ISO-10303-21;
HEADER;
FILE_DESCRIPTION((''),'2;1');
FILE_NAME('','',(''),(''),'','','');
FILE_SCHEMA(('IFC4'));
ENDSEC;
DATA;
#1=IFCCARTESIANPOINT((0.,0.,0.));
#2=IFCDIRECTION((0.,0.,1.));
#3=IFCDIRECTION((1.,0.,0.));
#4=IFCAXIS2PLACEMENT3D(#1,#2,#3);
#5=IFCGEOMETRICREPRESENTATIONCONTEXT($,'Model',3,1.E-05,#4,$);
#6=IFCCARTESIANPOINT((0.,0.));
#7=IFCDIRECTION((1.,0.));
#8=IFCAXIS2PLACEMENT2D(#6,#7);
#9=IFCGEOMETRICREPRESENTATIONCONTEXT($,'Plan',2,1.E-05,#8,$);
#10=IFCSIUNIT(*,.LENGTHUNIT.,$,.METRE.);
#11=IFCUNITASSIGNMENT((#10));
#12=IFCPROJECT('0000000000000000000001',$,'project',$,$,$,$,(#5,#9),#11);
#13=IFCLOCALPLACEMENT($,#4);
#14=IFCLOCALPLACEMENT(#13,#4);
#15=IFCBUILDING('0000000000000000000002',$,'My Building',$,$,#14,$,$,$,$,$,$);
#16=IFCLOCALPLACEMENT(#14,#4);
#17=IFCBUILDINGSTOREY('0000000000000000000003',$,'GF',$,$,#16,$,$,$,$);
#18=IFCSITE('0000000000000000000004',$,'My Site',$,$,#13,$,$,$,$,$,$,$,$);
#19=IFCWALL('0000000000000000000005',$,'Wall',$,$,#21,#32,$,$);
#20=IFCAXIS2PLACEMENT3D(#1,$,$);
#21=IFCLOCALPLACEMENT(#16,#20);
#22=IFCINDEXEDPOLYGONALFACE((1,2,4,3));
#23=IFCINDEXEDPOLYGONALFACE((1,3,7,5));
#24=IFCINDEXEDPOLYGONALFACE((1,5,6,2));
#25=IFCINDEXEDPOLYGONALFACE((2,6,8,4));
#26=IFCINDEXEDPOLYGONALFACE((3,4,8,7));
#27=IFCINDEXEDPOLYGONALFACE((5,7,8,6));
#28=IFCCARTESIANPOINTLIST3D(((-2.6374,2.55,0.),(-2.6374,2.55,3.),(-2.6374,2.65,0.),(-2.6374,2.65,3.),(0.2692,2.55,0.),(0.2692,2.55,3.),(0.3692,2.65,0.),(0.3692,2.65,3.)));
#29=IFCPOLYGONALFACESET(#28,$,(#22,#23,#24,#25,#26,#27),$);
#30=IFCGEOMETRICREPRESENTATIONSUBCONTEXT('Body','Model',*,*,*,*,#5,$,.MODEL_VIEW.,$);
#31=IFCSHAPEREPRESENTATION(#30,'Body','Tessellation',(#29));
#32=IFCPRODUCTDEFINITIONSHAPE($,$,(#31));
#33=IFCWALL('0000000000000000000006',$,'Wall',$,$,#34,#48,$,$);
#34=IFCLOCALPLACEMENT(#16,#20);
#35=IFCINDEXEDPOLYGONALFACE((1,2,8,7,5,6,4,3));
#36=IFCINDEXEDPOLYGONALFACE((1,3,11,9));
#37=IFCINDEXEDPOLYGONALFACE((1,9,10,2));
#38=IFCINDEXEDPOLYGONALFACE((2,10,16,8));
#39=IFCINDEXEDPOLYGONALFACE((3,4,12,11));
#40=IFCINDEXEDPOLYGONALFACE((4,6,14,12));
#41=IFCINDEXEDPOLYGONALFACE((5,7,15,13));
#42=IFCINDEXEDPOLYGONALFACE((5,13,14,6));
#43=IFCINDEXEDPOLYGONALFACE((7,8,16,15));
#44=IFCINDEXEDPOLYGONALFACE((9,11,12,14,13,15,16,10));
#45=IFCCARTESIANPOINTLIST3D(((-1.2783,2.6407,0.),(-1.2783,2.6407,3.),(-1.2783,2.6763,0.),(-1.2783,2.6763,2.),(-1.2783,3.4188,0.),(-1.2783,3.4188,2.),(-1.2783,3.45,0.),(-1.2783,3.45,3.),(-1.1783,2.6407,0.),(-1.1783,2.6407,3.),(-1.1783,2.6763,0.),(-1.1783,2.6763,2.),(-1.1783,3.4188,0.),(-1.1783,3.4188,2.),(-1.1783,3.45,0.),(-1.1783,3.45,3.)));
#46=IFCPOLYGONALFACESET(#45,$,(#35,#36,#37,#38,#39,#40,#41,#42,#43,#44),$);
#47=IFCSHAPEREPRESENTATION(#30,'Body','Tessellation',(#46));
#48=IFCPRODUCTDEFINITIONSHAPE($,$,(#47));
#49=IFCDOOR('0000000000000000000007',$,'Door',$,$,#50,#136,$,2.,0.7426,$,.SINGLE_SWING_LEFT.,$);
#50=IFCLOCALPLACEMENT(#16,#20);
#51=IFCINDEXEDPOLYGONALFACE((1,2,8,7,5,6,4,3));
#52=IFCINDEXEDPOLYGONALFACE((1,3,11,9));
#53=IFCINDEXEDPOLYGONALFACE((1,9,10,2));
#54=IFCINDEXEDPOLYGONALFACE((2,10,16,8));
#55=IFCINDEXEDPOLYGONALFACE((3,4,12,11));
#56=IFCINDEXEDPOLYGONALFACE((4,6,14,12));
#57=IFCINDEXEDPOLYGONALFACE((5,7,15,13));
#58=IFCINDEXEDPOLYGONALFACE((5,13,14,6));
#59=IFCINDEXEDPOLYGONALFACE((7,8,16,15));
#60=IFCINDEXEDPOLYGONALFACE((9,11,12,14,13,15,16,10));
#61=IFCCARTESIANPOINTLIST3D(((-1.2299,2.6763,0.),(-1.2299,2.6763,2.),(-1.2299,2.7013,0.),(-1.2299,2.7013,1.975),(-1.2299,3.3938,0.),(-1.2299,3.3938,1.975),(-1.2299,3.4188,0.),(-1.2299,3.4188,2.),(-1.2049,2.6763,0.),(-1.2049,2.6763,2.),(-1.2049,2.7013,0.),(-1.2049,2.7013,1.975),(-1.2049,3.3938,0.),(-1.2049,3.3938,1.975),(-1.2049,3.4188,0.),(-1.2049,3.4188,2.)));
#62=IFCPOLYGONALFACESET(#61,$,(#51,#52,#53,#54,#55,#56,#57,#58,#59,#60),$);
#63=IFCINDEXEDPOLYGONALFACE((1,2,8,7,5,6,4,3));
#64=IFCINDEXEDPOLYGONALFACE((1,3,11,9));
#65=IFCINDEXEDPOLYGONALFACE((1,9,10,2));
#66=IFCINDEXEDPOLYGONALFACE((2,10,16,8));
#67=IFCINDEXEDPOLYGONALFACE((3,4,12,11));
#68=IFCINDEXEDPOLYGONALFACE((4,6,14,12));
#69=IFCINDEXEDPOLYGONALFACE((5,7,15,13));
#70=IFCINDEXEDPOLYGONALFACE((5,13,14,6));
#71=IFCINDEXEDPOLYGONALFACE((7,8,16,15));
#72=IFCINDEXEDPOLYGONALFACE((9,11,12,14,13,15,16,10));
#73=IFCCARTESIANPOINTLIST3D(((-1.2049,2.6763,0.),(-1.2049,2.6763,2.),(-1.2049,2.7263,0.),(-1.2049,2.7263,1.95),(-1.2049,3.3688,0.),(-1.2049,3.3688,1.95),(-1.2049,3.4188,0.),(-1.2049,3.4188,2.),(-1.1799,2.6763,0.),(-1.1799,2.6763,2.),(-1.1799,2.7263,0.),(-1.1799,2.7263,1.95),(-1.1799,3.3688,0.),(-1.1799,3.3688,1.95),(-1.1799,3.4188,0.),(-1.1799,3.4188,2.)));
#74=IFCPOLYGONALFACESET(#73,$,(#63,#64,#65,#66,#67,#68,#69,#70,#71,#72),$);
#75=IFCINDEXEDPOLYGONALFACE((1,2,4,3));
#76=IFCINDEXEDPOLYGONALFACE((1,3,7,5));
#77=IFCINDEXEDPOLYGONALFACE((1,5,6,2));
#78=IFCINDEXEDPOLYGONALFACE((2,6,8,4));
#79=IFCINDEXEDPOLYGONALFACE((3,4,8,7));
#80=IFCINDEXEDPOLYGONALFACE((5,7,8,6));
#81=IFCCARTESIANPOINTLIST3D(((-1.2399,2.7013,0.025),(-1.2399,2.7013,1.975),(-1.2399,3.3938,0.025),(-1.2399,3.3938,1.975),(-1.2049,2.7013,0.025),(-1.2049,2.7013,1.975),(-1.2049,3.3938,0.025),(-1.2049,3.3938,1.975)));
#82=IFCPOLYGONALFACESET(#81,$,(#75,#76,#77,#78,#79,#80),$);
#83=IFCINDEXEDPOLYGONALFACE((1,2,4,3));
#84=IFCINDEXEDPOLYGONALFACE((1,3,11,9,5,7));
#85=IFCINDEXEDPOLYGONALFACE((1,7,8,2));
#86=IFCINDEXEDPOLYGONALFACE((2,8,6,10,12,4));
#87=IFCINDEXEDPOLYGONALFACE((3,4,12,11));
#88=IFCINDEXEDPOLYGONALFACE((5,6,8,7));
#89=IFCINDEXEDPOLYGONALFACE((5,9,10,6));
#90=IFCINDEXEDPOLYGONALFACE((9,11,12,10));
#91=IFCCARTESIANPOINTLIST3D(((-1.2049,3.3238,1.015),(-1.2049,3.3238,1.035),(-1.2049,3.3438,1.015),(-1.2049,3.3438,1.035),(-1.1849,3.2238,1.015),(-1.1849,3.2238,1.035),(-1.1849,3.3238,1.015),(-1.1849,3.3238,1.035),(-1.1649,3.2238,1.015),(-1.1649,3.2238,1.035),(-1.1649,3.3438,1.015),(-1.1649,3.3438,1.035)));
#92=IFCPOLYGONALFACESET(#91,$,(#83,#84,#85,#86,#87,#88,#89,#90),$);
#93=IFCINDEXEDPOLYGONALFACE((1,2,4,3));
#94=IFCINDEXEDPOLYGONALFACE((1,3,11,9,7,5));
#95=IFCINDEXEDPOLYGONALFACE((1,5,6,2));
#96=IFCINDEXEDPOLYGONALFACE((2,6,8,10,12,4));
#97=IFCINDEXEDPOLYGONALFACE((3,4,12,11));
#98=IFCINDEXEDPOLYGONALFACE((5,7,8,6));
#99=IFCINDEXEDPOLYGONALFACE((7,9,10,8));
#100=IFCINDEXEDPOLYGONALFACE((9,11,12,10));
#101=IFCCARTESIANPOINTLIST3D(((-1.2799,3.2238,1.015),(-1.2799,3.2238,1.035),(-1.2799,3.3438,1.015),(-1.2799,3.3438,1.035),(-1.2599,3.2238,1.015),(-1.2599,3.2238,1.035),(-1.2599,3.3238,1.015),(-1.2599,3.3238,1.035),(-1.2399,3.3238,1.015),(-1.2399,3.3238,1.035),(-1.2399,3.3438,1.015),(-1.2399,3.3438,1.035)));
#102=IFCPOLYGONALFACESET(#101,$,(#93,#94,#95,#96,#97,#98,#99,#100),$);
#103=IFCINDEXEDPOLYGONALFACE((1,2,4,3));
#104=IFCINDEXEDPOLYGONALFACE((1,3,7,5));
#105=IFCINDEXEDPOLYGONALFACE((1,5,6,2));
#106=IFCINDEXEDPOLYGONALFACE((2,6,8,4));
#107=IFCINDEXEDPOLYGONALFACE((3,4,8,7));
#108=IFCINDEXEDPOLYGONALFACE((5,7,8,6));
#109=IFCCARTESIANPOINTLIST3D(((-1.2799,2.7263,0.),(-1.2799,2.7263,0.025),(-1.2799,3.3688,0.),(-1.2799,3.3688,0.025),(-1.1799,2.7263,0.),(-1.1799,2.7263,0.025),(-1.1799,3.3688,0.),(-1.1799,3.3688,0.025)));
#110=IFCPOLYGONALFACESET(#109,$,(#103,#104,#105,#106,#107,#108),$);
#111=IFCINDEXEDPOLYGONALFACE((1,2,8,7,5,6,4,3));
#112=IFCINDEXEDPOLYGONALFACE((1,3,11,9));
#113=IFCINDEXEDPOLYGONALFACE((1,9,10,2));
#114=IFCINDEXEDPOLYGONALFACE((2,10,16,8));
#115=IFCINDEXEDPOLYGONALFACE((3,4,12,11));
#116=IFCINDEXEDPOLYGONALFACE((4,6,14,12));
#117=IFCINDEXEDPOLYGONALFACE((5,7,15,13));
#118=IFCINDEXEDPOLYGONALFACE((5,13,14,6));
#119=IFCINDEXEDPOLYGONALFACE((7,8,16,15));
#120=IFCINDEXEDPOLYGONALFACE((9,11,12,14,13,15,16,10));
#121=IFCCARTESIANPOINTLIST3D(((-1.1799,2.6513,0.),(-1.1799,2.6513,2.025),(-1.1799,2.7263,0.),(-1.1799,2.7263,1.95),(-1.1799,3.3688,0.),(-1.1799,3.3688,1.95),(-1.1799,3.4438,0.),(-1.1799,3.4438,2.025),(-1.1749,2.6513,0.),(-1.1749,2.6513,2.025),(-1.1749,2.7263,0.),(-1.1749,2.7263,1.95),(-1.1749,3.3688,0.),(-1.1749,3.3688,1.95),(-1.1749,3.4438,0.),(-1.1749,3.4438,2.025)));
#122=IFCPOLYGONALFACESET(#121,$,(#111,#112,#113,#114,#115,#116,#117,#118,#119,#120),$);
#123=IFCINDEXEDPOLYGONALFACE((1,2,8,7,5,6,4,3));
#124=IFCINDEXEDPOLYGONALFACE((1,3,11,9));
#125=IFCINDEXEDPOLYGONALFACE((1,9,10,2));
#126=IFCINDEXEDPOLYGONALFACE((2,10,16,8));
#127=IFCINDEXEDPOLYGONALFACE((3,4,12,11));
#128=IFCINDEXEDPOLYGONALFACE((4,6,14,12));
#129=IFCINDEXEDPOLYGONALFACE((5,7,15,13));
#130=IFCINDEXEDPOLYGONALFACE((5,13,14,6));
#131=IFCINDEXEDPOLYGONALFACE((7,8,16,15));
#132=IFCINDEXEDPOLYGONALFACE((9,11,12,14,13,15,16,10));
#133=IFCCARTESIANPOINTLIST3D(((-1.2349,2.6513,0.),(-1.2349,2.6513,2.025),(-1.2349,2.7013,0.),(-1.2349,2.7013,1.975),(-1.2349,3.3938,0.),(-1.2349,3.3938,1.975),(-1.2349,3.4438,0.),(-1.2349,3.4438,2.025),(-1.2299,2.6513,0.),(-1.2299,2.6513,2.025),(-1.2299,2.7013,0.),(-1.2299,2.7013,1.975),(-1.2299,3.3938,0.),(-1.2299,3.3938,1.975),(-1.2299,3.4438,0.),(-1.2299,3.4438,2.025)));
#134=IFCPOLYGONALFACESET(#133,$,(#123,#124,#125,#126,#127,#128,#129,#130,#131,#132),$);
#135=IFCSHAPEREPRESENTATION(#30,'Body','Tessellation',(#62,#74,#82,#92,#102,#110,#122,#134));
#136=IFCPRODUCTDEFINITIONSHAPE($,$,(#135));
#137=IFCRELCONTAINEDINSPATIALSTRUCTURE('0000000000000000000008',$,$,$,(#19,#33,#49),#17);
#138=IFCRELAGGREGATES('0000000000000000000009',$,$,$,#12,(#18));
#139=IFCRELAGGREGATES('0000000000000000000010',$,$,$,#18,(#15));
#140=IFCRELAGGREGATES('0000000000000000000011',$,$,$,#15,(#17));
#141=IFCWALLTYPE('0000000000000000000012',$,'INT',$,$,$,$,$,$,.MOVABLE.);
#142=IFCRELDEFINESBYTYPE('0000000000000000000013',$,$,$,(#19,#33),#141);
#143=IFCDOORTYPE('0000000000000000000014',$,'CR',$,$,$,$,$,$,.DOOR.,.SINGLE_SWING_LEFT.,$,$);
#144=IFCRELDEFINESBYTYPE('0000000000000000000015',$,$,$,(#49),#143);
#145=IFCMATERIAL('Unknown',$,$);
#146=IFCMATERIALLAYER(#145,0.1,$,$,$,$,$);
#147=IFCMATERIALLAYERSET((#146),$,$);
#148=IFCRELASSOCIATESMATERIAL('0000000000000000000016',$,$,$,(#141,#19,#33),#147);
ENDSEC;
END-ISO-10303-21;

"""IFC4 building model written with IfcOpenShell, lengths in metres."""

from ifc_helpers import new_model, entity, si_unit, frame, origin_with_axes, origin_2d_with_axis, place, context, subcontext, project, spatial, line, indexed_curve, outline, extrude, shape, source, transform, mapped, material, layer, layer_set, layer_usage, type_object, type_shapes, element, fill, save


model = new_model("IFC4")

# Units and contexts
model_context = context("Model", 3, precision=1e-05, world=origin_with_axes())
plan_context = context("Plan", 2, precision=1e-05, world=origin_2d_with_axis())
body_context_1 = subcontext(model_context, "Body", "Model", "MODEL_VIEW")
body_context_2 = subcontext(plan_context, "Body", "Plan", "PLAN_VIEW")
ifc_project = project(units=[si_unit("LENGTHUNIT", "METRE")], contexts=[model_context, plan_context])

# Site, building, storey
site_placement = place(None, origin_with_axes())
site = spatial("IfcSite", under=ifc_project, at=site_placement, Name="My Site")
building_placement = place(site_placement, origin_with_axes())
building = spatial("IfcBuilding", under=site, at=building_placement, Name="My Building")
storey_placement = place(building_placement, origin_with_axes())
storey = spatial("IfcBuildingStorey", under=building, at=storey_placement, Name="GF")

# Shared definitions
ifc_material = material(Name="Unknown")

# Wall
ifc_layer_1 = layer(ifc_material, 0.1)
ifc_layer_set_1 = layer_set([ifc_layer_1])
wall_type_1 = type_object("IfcWallType", Name="INT", PredefinedType="MOVABLE", material=ifc_layer_set_1)
ifc_layer_usage_1 = layer_usage(ifc_layer_set_1, "AXIS2", "POSITIVE", 0.0)
wall_1_placement = place(storey_placement, frame((0.3692, 2.65, 0.0), z_axis=(0.0, 0.0, 1.0), x_axis=(-1.0, 0.0, 0.0)))
element("IfcWall", 1, at=wall_1_placement, inside=storey, type_object=wall_type_1, material=ifc_layer_usage_1, Name="Wall", context=body_context_1, shape_type="SweptSolid", body=[
    extrude(outline(indexed_curve([(0.0, 0.0), (0.1, 0.1), (3.0066, 0.1), (3.0066, 0.0)], segments=[line(1, 2, 3, 4, 1)])), origin_with_axes(), (0.0, 0.0, 1.0), 3.0),
])

# Wall, opening, door
ifc_layer_usage_2 = layer_usage(ifc_layer_set_1, "AXIS2", "POSITIVE", 0.0)
wall_2_placement = place(storey_placement, frame((-1.2783, 3.45, 0.0), z_axis=(0.0, 0.0, 1.0), x_axis=(0.0, -1.0, 0.0)))
wall_2 = element("IfcWall", 2, at=wall_2_placement, inside=storey, type_object=wall_type_1, material=ifc_layer_usage_2, Name="Wall", context=body_context_1, shape_type="SweptSolid", body=[
    extrude(outline(indexed_curve([(0.0, 0.0), (0.0, 0.1), (0.8093, 0.1), (0.8093, 0.0)], segments=[line(1, 2, 3, 4, 1)])), origin_with_axes(), (0.0, 0.0, 1.0), 3.0),
])
shared_shape_1 = source(origin_with_axes(), body_context_1, "Body", "SweptSolid", [
    extrude(outline(indexed_curve([(0.0, 0.0), (0.7426, 0.0), (0.7426, 2.0), (0.0, 2.0)], segments=[line(1, 2, 3, 4, 1)])), frame((0.0, -0.6, 0.0), z_axis=(0.0, -1.0, 0.0), x_axis=(1.0, 0.0, 0.0)), (0.0, 0.0, -1.0), 1.2),
])
opening_1_placement = place(wall_2_placement, frame((0.7738, 0.0984, 0.0), z_axis=(0.0, 0.0, 1.0), x_axis=(-1.0, 0.0, 0.0)))
opening_1 = element("IfcOpeningElement", 3, at=opening_1_placement, cuts=wall_2, PredefinedType="OPENING", context=body_context_1, shape_type="MappedRepresentation", body=[
    mapped(shared_shape_1, transform((0.0, 0.0, 0.0), x_axis=(1.0, 0.0, 0.0), y_axis=(0.0, 1.0, 0.0), z_axis=(0.0, 0.0, 1.0), scale=1.0)),
])
door_type = type_object("IfcDoorType", Name="CR", OperationType="SINGLE_SWING_LEFT", PredefinedType="DOOR")
shared_shape_2 = source(origin_with_axes(), body_context_1, "Body", "SweptSolid", [
    extrude(outline(indexed_curve([(0.0, 0.0), (0.0, 2.0), (0.7426, 2.0), (0.7426, 0.0), (0.7176, 0.0), (0.7176, 1.975), (0.025, 1.975), (0.025, 0.0)], segments=[line(1, 2, 3, 4, 5, 6, 7, 8, 1)])), frame((0.0, 0.025, 0.0), z_axis=(0.0, -1.0, 0.0), x_axis=(1.0, 0.0, 0.0)), (0.0, 0.0, -1.0), 0.025),
    extrude(outline(indexed_curve([(0.0, 0.0), (0.0, 2.0), (0.7426, 2.0), (0.7426, 0.0), (0.6926, 0.0), (0.6926, 1.95), (0.05, 1.95), (0.05, 0.0)], segments=[line(1, 2, 3, 4, 5, 6, 7, 8, 1)])), frame((0.0, 0.0, 0.0), z_axis=(0.0, -1.0, 0.0), x_axis=(1.0, 0.0, 0.0)), (0.0, 0.0, -1.0), 0.025),
    extrude(outline(indexed_curve([(0.0, 0.0), (0.6926, 0.0), (0.6926, 0.035), (0.0, 0.035)], segments=[line(1, 2, 3, 4, 1)])), frame((0.025, 0.025, 0.025), z_axis=(0.0, 0.0, 1.0), x_axis=(1.0, 0.0, 0.0)), (0.0, 0.0, 1.0), 1.95),
    extrude(outline(indexed_curve([(0.0, 0.0), (0.0, -0.04), (-0.12, -0.04), (-0.12, -0.02), (-0.02, -0.02), (-0.02, 0.0)], segments=[line(1, 2, 3, 4, 5, 6, 1)])), frame((0.6676, 0.025, 1.015), z_axis=(0.0, 0.0, 1.0), x_axis=(1.0, 0.0, 0.0)), (0.0, 0.0, 1.0), 0.02),
    extrude(outline(indexed_curve([(0.0, 0.0), (0.0, 0.04), (-0.12, 0.04), (-0.12, 0.02), (-0.02, 0.02), (-0.02, 0.0)], segments=[line(1, 2, 3, 4, 5, 6, 1)])), frame((0.6676, 0.06, 1.015), z_axis=(0.0, 0.0, 1.0), x_axis=(1.0, 0.0, 0.0)), (0.0, 0.0, 1.0), 0.02),
    extrude(outline(indexed_curve([(0.0, 0.0), (0.6426, 0.0), (0.6426, 0.1), (0.0, 0.1)], segments=[line(1, 2, 3, 4, 1)])), frame((0.05, 0.0, 0.0), z_axis=(0.0, 0.0, 1.0), x_axis=(1.0, 0.0, 0.0)), (0.0, 0.0, 1.0), 0.025),
    extrude(outline(indexed_curve([(0.0, 0.0), (0.0, 2.025), (0.7926, 2.025), (0.7926, 0.0), (0.7176, 0.0), (0.7176, 1.95), (0.075, 1.95), (0.075, 0.0)], segments=[line(1, 2, 3, 4, 5, 6, 7, 8, 1)])), frame((-0.025, -0.005, 0.0), z_axis=(0.0, -1.0, 0.0), x_axis=(1.0, 0.0, 0.0)), (0.0, 0.0, -1.0), 0.005),
    extrude(outline(indexed_curve([(0.0, 0.0), (0.0, 2.025), (0.7926, 2.025), (0.7926, 0.0), (0.7426, 0.0), (0.7426, 1.975), (0.05, 1.975), (0.05, 0.0)], segments=[line(1, 2, 3, 4, 5, 6, 7, 8, 1)])), frame((-0.025, 0.05, 0.0), z_axis=(0.0, -1.0, 0.0), x_axis=(1.0, 0.0, 0.0)), (0.0, 0.0, -1.0), 0.005),
])
shared_shape_3 = source(origin_with_axes(), body_context_2, "Body", "Curve2D", [
    entity("IfcIndexedPolyCurve", entity("IfcCartesianPointList2D", [[0.0, 0.0], [0.0, 0.05], [0.025, 0.05], [0.025, 0.025], [0.05, 0.025], [0.05, 0.0]]), [entity("IfcLineIndex", [1, 2, 3, 4, 5, 6, 1])]),
    entity("IfcIndexedPolyCurve", entity("IfcCartesianPointList2D", [[0.7426, 0.0], [0.7426, 0.05], [0.7176, 0.05], [0.7176, 0.025], [0.6926, 0.025], [0.6926, 0.0]]), [entity("IfcLineIndex", [1, 2, 3, 4, 5, 6, 1])]),
    entity("IfcTrimmedCurve", entity("IfcEllipse", entity("IfcAxis2Placement2D", entity("IfcCartesianPoint", [0.06, 0.05]), entity("IfcDirection", [1.0, 0.0])), 0.6576, 0.6926), [entity("IfcCartesianPoint", [0.7176, 0.05])], [entity("IfcCartesianPoint", [0.06, 0.7426])], True, "CARTESIAN"),
    entity("IfcIndexedPolyCurve", entity("IfcCartesianPointList2D", [[0.025, 0.05], [0.06, 0.05], [0.06, 0.7426], [0.025, 0.7426]]), [entity("IfcLineIndex", [1, 2, 3, 4, 1])]),
])
type_shapes(door_type, [shared_shape_2, shared_shape_3])
door_placement = place(opening_1_placement, origin_with_axes())
door = element("IfcDoor", 4, at=door_placement, inside=storey, type_object=door_type, Name="Door", OperationType="SINGLE_SWING_LEFT", OverallHeight=2.0, OverallWidth=0.7426, shapes=[
    shape(body_context_1, "Body", "MappedRepresentation", [mapped(shared_shape_2, transform((0.0, 0.0, 0.0), x_axis=(1.0, 0.0, 0.0), y_axis=(0.0, 1.0, 0.0), z_axis=(0.0, 0.0, 1.0), scale=1.0))]),
    shape(body_context_2, "Body", "MappedRepresentation", [mapped(shared_shape_3, transform((0.0, 0.0, 0.0), x_axis=(1.0, 0.0, 0.0), y_axis=(0.0, 1.0, 0.0), z_axis=(0.0, 0.0, 1.0), scale=1.0))]),
])
fill(opening_1, door)

save(model, "model.ifc")
